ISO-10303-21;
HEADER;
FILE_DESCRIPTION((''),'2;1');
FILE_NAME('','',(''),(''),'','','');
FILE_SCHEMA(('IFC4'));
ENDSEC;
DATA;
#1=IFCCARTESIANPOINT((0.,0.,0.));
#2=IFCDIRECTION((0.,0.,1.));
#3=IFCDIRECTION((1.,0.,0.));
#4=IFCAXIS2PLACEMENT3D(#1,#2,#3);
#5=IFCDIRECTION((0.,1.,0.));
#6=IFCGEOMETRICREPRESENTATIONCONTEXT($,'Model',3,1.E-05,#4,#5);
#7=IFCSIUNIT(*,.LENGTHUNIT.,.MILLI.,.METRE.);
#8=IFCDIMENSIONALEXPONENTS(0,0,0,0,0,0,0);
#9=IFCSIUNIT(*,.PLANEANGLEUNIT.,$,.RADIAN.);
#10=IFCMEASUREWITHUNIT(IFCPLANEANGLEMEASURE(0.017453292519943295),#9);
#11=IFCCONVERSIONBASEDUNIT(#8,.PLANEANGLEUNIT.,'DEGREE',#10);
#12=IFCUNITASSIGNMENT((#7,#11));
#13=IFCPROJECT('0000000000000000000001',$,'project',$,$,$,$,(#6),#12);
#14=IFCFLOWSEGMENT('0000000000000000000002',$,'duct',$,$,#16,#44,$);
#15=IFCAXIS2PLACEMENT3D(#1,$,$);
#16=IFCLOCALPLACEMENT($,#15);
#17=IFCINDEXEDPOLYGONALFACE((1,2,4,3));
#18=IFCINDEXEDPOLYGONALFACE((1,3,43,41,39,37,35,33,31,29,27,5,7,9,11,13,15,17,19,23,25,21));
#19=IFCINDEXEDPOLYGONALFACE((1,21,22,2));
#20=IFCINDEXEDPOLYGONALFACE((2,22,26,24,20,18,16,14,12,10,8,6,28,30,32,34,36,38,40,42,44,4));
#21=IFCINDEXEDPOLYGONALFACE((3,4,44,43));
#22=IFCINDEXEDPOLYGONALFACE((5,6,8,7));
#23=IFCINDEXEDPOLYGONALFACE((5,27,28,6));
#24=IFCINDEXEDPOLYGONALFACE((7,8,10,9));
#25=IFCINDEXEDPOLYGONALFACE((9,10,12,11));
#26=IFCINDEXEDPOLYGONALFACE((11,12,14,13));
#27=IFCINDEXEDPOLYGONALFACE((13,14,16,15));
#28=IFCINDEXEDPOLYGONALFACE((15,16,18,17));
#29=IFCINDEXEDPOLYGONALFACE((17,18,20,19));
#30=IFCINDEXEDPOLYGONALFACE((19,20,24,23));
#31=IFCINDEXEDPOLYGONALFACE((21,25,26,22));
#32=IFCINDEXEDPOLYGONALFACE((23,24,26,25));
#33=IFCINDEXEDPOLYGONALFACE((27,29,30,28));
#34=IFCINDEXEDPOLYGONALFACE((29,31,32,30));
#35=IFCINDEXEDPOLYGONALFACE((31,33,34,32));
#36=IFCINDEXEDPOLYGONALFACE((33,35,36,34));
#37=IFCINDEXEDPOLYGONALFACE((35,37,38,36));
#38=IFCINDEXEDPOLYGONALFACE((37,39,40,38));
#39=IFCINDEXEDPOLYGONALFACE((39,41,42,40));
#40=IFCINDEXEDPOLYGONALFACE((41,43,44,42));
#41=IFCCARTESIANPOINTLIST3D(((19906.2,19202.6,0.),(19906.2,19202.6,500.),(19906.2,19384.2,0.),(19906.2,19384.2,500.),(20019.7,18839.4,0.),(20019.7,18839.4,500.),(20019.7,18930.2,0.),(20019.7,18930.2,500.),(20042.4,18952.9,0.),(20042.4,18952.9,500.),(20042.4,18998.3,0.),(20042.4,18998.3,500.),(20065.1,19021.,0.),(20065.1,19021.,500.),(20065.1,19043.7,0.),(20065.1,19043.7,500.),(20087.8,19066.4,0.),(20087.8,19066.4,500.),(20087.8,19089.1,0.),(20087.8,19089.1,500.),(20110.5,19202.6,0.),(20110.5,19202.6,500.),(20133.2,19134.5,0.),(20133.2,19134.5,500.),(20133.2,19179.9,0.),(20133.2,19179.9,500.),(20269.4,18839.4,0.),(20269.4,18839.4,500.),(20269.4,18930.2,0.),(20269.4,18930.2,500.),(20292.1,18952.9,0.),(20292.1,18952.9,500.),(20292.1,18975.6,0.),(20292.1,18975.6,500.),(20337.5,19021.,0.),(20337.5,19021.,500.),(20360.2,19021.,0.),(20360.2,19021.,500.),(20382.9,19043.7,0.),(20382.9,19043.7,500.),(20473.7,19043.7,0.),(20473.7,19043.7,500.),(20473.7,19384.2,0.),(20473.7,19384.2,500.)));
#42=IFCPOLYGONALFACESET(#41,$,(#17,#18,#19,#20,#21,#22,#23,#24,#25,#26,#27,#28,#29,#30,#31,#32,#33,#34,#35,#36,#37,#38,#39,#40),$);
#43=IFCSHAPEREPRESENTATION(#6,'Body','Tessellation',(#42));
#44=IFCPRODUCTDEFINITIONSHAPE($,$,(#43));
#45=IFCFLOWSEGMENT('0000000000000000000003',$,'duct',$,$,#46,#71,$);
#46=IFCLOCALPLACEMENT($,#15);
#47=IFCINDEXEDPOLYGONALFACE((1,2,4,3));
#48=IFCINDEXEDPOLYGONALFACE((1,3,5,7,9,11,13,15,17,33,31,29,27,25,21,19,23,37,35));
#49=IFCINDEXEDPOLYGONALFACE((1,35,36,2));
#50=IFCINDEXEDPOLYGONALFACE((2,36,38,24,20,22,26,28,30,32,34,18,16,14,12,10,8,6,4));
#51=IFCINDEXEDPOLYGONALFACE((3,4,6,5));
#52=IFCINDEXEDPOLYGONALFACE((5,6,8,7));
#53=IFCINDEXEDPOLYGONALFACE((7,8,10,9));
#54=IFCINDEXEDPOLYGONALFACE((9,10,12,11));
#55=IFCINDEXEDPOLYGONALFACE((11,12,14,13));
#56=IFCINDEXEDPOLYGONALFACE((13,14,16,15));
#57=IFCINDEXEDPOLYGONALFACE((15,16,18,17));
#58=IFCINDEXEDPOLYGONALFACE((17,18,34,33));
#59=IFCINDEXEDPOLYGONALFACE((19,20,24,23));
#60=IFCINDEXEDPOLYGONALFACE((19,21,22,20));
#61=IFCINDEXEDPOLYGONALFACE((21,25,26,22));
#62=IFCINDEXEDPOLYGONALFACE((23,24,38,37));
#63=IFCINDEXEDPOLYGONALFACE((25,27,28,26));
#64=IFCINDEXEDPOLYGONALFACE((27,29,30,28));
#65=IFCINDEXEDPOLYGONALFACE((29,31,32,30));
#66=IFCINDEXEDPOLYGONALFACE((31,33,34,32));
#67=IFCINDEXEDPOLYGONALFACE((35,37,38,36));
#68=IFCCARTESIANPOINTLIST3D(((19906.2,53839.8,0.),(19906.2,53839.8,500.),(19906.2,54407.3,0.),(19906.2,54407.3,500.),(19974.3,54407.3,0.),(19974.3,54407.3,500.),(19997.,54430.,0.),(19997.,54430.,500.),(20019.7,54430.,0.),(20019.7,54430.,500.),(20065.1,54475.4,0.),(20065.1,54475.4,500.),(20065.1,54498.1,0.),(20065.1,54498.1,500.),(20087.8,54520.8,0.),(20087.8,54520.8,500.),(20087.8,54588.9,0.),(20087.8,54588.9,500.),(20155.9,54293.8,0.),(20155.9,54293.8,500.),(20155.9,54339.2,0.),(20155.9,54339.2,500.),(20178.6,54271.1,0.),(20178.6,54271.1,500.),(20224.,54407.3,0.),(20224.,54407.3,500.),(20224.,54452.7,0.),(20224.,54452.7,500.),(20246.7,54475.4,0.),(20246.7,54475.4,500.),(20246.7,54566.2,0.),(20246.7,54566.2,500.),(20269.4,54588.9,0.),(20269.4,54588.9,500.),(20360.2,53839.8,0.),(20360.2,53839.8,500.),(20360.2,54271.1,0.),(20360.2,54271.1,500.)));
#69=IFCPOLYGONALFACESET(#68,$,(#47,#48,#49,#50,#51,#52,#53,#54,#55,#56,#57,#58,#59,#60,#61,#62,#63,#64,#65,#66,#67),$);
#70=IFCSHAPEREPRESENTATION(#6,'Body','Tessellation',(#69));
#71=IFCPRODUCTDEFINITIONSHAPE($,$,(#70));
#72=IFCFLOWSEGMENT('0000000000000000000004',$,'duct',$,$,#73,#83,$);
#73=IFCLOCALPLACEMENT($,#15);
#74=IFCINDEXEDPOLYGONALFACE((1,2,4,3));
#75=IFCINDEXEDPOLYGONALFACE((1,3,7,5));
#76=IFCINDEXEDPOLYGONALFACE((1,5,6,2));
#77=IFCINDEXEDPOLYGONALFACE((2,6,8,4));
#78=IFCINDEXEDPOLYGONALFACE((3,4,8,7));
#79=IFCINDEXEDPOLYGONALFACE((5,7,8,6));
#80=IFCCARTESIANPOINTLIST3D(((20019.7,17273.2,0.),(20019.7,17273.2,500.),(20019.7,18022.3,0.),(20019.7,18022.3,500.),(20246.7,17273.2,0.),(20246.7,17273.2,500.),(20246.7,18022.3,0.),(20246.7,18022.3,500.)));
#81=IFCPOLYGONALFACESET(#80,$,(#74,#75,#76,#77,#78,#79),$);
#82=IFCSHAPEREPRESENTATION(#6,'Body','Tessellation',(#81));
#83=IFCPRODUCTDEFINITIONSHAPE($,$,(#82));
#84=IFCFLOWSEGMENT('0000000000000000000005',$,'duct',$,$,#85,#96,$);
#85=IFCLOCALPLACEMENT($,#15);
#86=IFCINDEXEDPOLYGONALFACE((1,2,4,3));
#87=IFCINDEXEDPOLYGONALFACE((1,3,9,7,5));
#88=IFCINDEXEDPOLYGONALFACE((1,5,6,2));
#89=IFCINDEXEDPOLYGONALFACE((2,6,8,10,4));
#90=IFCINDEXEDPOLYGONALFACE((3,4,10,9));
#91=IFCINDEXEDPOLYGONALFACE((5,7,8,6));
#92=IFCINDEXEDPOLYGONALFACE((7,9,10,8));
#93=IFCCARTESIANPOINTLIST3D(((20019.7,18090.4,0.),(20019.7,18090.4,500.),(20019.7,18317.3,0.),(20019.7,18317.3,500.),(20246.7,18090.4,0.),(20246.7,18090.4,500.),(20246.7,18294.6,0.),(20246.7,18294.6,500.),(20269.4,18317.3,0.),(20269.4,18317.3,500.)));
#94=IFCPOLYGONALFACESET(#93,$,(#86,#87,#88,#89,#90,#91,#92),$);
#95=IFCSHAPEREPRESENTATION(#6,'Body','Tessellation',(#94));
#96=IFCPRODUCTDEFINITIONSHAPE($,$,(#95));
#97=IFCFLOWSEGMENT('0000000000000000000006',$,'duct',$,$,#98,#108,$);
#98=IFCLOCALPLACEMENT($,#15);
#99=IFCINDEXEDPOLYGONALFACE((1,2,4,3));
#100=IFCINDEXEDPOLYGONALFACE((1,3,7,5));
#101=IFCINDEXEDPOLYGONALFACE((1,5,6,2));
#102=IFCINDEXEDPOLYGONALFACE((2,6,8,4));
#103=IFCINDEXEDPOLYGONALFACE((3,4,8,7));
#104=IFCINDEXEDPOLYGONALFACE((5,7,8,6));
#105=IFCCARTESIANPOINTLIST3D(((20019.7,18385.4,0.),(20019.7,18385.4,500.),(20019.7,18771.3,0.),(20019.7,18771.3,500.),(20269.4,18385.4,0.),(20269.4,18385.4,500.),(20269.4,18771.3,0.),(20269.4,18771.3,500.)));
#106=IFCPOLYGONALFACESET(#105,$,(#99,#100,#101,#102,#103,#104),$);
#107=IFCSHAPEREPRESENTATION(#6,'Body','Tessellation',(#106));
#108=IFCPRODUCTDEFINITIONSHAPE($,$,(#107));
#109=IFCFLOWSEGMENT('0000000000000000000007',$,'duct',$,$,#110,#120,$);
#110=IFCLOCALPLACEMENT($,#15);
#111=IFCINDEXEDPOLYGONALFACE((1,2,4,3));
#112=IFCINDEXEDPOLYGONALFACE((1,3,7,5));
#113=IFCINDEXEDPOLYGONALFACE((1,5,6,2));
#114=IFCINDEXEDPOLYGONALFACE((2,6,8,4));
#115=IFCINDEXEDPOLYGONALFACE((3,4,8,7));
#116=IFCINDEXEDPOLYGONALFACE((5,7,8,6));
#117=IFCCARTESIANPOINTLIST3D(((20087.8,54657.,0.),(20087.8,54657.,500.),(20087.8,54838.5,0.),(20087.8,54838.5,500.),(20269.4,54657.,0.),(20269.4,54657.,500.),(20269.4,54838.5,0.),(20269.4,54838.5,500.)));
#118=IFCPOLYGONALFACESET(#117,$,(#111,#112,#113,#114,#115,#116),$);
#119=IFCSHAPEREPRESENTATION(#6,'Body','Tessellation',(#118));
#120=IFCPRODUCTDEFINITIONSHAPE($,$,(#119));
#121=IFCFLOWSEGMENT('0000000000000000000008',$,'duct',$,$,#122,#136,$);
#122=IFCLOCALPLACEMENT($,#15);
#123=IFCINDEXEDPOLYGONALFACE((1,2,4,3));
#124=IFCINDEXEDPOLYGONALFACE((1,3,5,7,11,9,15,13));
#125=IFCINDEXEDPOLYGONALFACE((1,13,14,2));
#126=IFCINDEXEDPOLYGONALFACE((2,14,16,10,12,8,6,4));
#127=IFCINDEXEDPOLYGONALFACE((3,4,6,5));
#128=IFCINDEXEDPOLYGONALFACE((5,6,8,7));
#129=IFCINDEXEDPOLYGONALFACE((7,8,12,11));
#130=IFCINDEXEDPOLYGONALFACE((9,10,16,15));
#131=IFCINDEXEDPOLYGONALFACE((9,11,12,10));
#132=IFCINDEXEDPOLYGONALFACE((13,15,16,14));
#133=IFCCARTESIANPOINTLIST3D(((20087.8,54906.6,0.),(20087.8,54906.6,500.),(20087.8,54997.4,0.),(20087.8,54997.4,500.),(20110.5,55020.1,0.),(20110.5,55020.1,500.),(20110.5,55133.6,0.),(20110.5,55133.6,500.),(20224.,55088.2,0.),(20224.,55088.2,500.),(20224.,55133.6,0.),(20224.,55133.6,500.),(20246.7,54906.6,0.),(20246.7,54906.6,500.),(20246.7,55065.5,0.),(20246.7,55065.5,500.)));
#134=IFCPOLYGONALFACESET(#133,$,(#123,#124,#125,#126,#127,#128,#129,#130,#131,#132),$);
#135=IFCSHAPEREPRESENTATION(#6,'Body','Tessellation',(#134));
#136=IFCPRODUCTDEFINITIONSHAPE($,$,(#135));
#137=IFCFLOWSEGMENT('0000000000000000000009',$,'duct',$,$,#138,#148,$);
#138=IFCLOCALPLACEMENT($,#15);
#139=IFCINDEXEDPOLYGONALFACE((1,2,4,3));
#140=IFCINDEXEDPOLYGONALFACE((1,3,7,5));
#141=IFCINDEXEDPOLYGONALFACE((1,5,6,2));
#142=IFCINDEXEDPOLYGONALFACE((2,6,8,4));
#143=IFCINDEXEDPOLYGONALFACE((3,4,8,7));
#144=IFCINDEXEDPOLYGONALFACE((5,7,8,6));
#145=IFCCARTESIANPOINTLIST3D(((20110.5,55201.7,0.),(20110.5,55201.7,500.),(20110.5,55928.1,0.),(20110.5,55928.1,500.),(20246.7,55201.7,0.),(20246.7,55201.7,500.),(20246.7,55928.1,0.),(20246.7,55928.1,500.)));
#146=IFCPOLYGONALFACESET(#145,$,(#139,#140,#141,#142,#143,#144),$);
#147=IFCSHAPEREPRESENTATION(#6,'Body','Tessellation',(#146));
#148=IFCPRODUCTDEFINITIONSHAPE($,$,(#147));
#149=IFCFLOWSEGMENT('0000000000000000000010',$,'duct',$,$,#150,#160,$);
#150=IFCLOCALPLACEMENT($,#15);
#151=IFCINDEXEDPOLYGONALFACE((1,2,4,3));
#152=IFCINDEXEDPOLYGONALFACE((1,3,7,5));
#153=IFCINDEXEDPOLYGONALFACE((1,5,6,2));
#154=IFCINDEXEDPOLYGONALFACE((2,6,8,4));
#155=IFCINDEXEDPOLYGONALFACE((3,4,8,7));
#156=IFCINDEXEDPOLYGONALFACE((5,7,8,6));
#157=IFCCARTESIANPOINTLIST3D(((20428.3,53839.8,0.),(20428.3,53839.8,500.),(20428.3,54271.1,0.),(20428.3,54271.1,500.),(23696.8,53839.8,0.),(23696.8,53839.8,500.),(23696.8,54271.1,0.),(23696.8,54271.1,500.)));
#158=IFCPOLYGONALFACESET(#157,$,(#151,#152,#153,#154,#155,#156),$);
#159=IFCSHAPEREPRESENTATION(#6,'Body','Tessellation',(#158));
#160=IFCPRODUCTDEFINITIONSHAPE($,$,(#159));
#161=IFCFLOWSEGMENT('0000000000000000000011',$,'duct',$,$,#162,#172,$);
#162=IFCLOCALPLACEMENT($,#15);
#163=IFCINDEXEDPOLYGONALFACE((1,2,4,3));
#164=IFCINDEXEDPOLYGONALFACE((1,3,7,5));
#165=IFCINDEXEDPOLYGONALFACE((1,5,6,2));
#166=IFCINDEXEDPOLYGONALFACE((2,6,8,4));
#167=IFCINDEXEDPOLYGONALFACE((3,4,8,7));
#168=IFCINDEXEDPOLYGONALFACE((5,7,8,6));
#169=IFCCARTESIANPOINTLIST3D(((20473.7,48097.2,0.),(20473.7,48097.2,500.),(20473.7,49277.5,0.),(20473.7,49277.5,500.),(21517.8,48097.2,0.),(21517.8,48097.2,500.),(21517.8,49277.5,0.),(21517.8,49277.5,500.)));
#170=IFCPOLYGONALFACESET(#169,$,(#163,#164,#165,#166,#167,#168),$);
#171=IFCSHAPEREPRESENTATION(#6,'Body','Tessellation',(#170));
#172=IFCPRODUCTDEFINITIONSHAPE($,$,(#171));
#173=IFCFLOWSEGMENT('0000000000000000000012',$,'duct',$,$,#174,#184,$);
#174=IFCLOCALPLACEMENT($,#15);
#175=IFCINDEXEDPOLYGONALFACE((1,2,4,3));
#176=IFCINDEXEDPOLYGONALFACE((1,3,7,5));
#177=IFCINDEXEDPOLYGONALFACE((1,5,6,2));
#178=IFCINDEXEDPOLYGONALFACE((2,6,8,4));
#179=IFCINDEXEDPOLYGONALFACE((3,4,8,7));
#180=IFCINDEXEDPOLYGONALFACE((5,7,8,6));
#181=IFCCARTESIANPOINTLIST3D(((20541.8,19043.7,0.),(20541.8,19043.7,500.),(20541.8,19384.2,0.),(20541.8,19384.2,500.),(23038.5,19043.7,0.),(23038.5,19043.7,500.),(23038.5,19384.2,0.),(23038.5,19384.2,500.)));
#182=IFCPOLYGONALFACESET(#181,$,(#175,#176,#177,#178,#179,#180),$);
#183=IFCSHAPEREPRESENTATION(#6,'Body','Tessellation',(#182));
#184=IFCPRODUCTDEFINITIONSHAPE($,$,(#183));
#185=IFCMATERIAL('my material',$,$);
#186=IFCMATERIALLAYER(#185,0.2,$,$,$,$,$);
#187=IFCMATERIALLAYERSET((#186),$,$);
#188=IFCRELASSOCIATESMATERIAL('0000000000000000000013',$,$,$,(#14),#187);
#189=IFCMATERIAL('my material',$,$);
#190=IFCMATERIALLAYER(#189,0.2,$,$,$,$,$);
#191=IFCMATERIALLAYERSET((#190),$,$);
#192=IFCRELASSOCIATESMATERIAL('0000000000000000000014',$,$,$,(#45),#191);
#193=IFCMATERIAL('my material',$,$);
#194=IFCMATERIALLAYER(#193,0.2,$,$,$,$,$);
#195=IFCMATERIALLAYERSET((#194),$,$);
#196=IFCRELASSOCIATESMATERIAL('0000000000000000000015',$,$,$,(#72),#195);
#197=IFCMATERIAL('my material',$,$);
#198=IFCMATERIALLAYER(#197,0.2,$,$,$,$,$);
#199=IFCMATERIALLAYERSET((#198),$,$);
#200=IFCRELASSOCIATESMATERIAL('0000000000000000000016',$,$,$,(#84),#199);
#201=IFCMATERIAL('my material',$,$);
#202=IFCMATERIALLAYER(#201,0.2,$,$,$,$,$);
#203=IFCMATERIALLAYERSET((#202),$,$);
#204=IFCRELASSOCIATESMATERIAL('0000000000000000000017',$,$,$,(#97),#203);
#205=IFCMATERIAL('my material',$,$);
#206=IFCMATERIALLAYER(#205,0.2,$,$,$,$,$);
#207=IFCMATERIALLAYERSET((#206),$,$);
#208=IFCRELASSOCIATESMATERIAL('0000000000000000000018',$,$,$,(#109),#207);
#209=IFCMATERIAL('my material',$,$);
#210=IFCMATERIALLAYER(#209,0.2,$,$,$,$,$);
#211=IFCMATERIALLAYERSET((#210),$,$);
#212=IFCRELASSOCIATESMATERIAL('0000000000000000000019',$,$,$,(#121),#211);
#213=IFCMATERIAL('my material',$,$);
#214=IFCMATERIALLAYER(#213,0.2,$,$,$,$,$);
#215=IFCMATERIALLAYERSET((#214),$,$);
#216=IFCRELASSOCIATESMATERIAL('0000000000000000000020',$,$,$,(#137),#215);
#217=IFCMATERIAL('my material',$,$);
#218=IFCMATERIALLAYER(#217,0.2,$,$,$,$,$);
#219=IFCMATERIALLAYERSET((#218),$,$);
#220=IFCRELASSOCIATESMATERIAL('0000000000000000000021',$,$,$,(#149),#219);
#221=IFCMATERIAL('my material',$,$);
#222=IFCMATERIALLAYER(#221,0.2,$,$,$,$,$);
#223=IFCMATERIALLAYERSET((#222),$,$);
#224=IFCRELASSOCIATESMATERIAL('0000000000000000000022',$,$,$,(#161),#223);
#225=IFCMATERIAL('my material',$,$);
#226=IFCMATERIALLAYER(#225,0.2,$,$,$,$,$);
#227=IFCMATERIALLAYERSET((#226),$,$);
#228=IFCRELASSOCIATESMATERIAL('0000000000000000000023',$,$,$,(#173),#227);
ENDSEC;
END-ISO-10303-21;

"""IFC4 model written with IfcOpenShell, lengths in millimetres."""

from ifc_helpers import new_model, entity, si_unit, converted_unit, direction, origin_with_axes, place, context, project, polyline, outline, extrude, material, layer, layer_set, layer_usage, element, save


model = new_model("IFC4")

# Units and contexts
model_context = context("Model", 3, precision=1e-05, world=origin_with_axes(), true_north=direction((0.0, 1.0, 0.0)))
ifc_project = project(units=[si_unit("LENGTHUNIT", "METRE", prefix="MILLI"), converted_unit("PLANEANGLEUNIT", "DEGREE", entity("IfcPlaneAngleMeasure", 0.017453292519943295), si_unit("PLANEANGLEUNIT", "RADIAN"), dimensions=[0, 0, 0, 0, 0, 0, 0])], contexts=[model_context])

# Flow segments
ifc_material_1 = material(Name="my material")
ifc_layer_1 = layer(ifc_material_1, 0.2)
ifc_layer_set_1 = layer_set([ifc_layer_1])
ifc_layer_usage_1 = layer_usage(ifc_layer_set_1, "AXIS2", "POSITIVE", -0.1)
flow_segment_1_placement = place(None, origin_with_axes())
element("IfcFlowSegment", 1, at=flow_segment_1_placement, material=ifc_layer_usage_1, Name="duct", context=model_context, shape_type="SweptSolid", body=[
    extrude(outline(polyline([(19906.2, 19202.6), (20110.5, 19202.6), (20133.2, 19179.9), (20133.2, 19134.5), (20087.8, 19089.1), (20087.8, 19066.4), (20065.1, 19043.7), (20065.1, 19021.0), (20042.4, 18998.3), (20042.4, 18952.9), (20019.7, 18930.2), (20019.7, 18839.4), (20269.4, 18839.4), (20269.4, 18930.2), (20292.1, 18952.9), (20292.1, 18975.6), (20337.5, 19021.0), (20360.2, 19021.0), (20382.9, 19043.7), (20473.7, 19043.7), (20473.7, 19384.2), (19906.2, 19384.2), (19906.2, 19202.6)])), origin_with_axes(), (0.0, 0.0, 1.0), 500.0),
])
ifc_material_2 = material(Name="my material")
ifc_layer_2 = layer(ifc_material_2, 0.2)
ifc_layer_set_2 = layer_set([ifc_layer_2])
ifc_layer_usage_2 = layer_usage(ifc_layer_set_2, "AXIS2", "POSITIVE", -0.1)
flow_segment_2_placement = place(None, origin_with_axes())
element("IfcFlowSegment", 2, at=flow_segment_2_placement, material=ifc_layer_usage_2, Name="duct", context=model_context, shape_type="SweptSolid", body=[
    extrude(outline(polyline([(19906.2, 53839.8), (20360.2, 53839.8), (20360.2, 54271.1), (20178.6, 54271.1), (20155.9, 54293.8), (20155.9, 54339.2), (20224.0, 54407.3), (20224.0, 54452.7), (20246.7, 54475.4), (20246.7, 54566.2), (20269.4, 54588.9), (20087.8, 54588.9), (20087.8, 54520.8), (20065.1, 54498.1), (20065.1, 54475.4), (20019.7, 54430.0), (19997.0, 54430.0), (19974.3, 54407.3), (19906.2, 54407.3), (19906.2, 53839.8)])), origin_with_axes(), (0.0, 0.0, 1.0), 500.0),
])
ifc_material_3 = material(Name="my material")
ifc_layer_3 = layer(ifc_material_3, 0.2)
ifc_layer_set_3 = layer_set([ifc_layer_3])
ifc_layer_usage_3 = layer_usage(ifc_layer_set_3, "AXIS2", "POSITIVE", -0.1)
flow_segment_3_placement = place(None, origin_with_axes())
element("IfcFlowSegment", 3, at=flow_segment_3_placement, material=ifc_layer_usage_3, Name="duct", context=model_context, shape_type="SweptSolid", body=[
    extrude(outline(polyline([(20019.7, 17273.2), (20246.7, 17273.2), (20246.7, 18022.3), (20019.7, 18022.3), (20019.7, 17273.2)])), origin_with_axes(), (0.0, 0.0, 1.0), 500.0),
])
ifc_material_4 = material(Name="my material")
ifc_layer_4 = layer(ifc_material_4, 0.2)
ifc_layer_set_4 = layer_set([ifc_layer_4])
ifc_layer_usage_4 = layer_usage(ifc_layer_set_4, "AXIS2", "POSITIVE", -0.1)
flow_segment_4_placement = place(None, origin_with_axes())
element("IfcFlowSegment", 4, at=flow_segment_4_placement, material=ifc_layer_usage_4, Name="duct", context=model_context, shape_type="SweptSolid", body=[
    extrude(outline(polyline([(20019.7, 18090.4), (20246.7, 18090.4), (20246.7, 18294.6), (20269.4, 18317.3), (20019.7, 18317.3), (20019.7, 18090.4)])), origin_with_axes(), (0.0, 0.0, 1.0), 500.0),
])
ifc_material_5 = material(Name="my material")
ifc_layer_5 = layer(ifc_material_5, 0.2)
ifc_layer_set_5 = layer_set([ifc_layer_5])
ifc_layer_usage_5 = layer_usage(ifc_layer_set_5, "AXIS2", "POSITIVE", -0.1)
flow_segment_5_placement = place(None, origin_with_axes())
element("IfcFlowSegment", 5, at=flow_segment_5_placement, material=ifc_layer_usage_5, Name="duct", context=model_context, shape_type="SweptSolid", body=[
    extrude(outline(polyline([(20019.7, 18385.4), (20269.4, 18385.4), (20269.4, 18771.3), (20019.7, 18771.3), (20019.7, 18385.4)])), origin_with_axes(), (0.0, 0.0, 1.0), 500.0),
])
ifc_material_6 = material(Name="my material")
ifc_layer_6 = layer(ifc_material_6, 0.2)
ifc_layer_set_6 = layer_set([ifc_layer_6])
ifc_layer_usage_6 = layer_usage(ifc_layer_set_6, "AXIS2", "POSITIVE", -0.1)
flow_segment_6_placement = place(None, origin_with_axes())
element("IfcFlowSegment", 6, at=flow_segment_6_placement, material=ifc_layer_usage_6, Name="duct", context=model_context, shape_type="SweptSolid", body=[
    extrude(outline(polyline([(20087.8, 54657.0), (20269.4, 54657.0), (20269.4, 54838.5), (20087.8, 54838.5), (20087.8, 54657.0)])), origin_with_axes(), (0.0, 0.0, 1.0), 500.0),
])
ifc_material_7 = material(Name="my material")
ifc_layer_7 = layer(ifc_material_7, 0.2)
ifc_layer_set_7 = layer_set([ifc_layer_7])
ifc_layer_usage_7 = layer_usage(ifc_layer_set_7, "AXIS2", "POSITIVE", -0.1)
flow_segment_7_placement = place(None, origin_with_axes())
element("IfcFlowSegment", 7, at=flow_segment_7_placement, material=ifc_layer_usage_7, Name="duct", context=model_context, shape_type="SweptSolid", body=[
    extrude(outline(polyline([(20087.8, 54906.6), (20246.7, 54906.6), (20246.7, 55065.5), (20224.0, 55088.2), (20224.0, 55133.6), (20110.5, 55133.6), (20110.5, 55020.1), (20087.8, 54997.4), (20087.8, 54906.6)])), origin_with_axes(), (0.0, 0.0, 1.0), 500.0),
])
ifc_material_8 = material(Name="my material")
ifc_layer_8 = layer(ifc_material_8, 0.2)
ifc_layer_set_8 = layer_set([ifc_layer_8])
ifc_layer_usage_8 = layer_usage(ifc_layer_set_8, "AXIS2", "POSITIVE", -0.1)
flow_segment_8_placement = place(None, origin_with_axes())
element("IfcFlowSegment", 8, at=flow_segment_8_placement, material=ifc_layer_usage_8, Name="duct", context=model_context, shape_type="SweptSolid", body=[
    extrude(outline(polyline([(20110.5, 55201.7), (20246.7, 55201.7), (20246.7, 55928.1), (20110.5, 55928.1), (20110.5, 55201.7)])), origin_with_axes(), (0.0, 0.0, 1.0), 500.0),
])
ifc_material_9 = material(Name="my material")
ifc_layer_9 = layer(ifc_material_9, 0.2)
ifc_layer_set_9 = layer_set([ifc_layer_9])
ifc_layer_usage_9 = layer_usage(ifc_layer_set_9, "AXIS2", "POSITIVE", -0.1)
flow_segment_9_placement = place(None, origin_with_axes())
element("IfcFlowSegment", 9, at=flow_segment_9_placement, material=ifc_layer_usage_9, Name="duct", context=model_context, shape_type="SweptSolid", body=[
    extrude(outline(polyline([(20428.3, 53839.8), (23696.8, 53839.8), (23696.8, 54271.1), (20428.3, 54271.1), (20428.3, 53839.8)])), origin_with_axes(), (0.0, 0.0, 1.0), 500.0),
])
ifc_material_10 = material(Name="my material")
ifc_layer_10 = layer(ifc_material_10, 0.2)
ifc_layer_set_10 = layer_set([ifc_layer_10])
ifc_layer_usage_10 = layer_usage(ifc_layer_set_10, "AXIS2", "POSITIVE", -0.1)
flow_segment_10_placement = place(None, origin_with_axes())
element("IfcFlowSegment", 10, at=flow_segment_10_placement, material=ifc_layer_usage_10, Name="duct", context=model_context, shape_type="SweptSolid", body=[
    extrude(outline(polyline([(20473.7, 48097.2), (21517.8, 48097.2), (21517.8, 49277.5), (20473.7, 49277.5), (20473.7, 48097.2)])), origin_with_axes(), (0.0, 0.0, 1.0), 500.0),
])
ifc_material_11 = material(Name="my material")
ifc_layer_11 = layer(ifc_material_11, 0.2)
ifc_layer_set_11 = layer_set([ifc_layer_11])
ifc_layer_usage_11 = layer_usage(ifc_layer_set_11, "AXIS2", "POSITIVE", -0.1)
flow_segment_11_placement = place(None, origin_with_axes())
element("IfcFlowSegment", 11, at=flow_segment_11_placement, material=ifc_layer_usage_11, Name="duct", context=model_context, shape_type="SweptSolid", body=[
    extrude(outline(polyline([(20541.8, 19043.7), (23038.5, 19043.7), (23038.5, 19384.2), (20541.8, 19384.2), (20541.8, 19043.7)])), origin_with_axes(), (0.0, 0.0, 1.0), 500.0),
])

save(model, "model.ifc")
